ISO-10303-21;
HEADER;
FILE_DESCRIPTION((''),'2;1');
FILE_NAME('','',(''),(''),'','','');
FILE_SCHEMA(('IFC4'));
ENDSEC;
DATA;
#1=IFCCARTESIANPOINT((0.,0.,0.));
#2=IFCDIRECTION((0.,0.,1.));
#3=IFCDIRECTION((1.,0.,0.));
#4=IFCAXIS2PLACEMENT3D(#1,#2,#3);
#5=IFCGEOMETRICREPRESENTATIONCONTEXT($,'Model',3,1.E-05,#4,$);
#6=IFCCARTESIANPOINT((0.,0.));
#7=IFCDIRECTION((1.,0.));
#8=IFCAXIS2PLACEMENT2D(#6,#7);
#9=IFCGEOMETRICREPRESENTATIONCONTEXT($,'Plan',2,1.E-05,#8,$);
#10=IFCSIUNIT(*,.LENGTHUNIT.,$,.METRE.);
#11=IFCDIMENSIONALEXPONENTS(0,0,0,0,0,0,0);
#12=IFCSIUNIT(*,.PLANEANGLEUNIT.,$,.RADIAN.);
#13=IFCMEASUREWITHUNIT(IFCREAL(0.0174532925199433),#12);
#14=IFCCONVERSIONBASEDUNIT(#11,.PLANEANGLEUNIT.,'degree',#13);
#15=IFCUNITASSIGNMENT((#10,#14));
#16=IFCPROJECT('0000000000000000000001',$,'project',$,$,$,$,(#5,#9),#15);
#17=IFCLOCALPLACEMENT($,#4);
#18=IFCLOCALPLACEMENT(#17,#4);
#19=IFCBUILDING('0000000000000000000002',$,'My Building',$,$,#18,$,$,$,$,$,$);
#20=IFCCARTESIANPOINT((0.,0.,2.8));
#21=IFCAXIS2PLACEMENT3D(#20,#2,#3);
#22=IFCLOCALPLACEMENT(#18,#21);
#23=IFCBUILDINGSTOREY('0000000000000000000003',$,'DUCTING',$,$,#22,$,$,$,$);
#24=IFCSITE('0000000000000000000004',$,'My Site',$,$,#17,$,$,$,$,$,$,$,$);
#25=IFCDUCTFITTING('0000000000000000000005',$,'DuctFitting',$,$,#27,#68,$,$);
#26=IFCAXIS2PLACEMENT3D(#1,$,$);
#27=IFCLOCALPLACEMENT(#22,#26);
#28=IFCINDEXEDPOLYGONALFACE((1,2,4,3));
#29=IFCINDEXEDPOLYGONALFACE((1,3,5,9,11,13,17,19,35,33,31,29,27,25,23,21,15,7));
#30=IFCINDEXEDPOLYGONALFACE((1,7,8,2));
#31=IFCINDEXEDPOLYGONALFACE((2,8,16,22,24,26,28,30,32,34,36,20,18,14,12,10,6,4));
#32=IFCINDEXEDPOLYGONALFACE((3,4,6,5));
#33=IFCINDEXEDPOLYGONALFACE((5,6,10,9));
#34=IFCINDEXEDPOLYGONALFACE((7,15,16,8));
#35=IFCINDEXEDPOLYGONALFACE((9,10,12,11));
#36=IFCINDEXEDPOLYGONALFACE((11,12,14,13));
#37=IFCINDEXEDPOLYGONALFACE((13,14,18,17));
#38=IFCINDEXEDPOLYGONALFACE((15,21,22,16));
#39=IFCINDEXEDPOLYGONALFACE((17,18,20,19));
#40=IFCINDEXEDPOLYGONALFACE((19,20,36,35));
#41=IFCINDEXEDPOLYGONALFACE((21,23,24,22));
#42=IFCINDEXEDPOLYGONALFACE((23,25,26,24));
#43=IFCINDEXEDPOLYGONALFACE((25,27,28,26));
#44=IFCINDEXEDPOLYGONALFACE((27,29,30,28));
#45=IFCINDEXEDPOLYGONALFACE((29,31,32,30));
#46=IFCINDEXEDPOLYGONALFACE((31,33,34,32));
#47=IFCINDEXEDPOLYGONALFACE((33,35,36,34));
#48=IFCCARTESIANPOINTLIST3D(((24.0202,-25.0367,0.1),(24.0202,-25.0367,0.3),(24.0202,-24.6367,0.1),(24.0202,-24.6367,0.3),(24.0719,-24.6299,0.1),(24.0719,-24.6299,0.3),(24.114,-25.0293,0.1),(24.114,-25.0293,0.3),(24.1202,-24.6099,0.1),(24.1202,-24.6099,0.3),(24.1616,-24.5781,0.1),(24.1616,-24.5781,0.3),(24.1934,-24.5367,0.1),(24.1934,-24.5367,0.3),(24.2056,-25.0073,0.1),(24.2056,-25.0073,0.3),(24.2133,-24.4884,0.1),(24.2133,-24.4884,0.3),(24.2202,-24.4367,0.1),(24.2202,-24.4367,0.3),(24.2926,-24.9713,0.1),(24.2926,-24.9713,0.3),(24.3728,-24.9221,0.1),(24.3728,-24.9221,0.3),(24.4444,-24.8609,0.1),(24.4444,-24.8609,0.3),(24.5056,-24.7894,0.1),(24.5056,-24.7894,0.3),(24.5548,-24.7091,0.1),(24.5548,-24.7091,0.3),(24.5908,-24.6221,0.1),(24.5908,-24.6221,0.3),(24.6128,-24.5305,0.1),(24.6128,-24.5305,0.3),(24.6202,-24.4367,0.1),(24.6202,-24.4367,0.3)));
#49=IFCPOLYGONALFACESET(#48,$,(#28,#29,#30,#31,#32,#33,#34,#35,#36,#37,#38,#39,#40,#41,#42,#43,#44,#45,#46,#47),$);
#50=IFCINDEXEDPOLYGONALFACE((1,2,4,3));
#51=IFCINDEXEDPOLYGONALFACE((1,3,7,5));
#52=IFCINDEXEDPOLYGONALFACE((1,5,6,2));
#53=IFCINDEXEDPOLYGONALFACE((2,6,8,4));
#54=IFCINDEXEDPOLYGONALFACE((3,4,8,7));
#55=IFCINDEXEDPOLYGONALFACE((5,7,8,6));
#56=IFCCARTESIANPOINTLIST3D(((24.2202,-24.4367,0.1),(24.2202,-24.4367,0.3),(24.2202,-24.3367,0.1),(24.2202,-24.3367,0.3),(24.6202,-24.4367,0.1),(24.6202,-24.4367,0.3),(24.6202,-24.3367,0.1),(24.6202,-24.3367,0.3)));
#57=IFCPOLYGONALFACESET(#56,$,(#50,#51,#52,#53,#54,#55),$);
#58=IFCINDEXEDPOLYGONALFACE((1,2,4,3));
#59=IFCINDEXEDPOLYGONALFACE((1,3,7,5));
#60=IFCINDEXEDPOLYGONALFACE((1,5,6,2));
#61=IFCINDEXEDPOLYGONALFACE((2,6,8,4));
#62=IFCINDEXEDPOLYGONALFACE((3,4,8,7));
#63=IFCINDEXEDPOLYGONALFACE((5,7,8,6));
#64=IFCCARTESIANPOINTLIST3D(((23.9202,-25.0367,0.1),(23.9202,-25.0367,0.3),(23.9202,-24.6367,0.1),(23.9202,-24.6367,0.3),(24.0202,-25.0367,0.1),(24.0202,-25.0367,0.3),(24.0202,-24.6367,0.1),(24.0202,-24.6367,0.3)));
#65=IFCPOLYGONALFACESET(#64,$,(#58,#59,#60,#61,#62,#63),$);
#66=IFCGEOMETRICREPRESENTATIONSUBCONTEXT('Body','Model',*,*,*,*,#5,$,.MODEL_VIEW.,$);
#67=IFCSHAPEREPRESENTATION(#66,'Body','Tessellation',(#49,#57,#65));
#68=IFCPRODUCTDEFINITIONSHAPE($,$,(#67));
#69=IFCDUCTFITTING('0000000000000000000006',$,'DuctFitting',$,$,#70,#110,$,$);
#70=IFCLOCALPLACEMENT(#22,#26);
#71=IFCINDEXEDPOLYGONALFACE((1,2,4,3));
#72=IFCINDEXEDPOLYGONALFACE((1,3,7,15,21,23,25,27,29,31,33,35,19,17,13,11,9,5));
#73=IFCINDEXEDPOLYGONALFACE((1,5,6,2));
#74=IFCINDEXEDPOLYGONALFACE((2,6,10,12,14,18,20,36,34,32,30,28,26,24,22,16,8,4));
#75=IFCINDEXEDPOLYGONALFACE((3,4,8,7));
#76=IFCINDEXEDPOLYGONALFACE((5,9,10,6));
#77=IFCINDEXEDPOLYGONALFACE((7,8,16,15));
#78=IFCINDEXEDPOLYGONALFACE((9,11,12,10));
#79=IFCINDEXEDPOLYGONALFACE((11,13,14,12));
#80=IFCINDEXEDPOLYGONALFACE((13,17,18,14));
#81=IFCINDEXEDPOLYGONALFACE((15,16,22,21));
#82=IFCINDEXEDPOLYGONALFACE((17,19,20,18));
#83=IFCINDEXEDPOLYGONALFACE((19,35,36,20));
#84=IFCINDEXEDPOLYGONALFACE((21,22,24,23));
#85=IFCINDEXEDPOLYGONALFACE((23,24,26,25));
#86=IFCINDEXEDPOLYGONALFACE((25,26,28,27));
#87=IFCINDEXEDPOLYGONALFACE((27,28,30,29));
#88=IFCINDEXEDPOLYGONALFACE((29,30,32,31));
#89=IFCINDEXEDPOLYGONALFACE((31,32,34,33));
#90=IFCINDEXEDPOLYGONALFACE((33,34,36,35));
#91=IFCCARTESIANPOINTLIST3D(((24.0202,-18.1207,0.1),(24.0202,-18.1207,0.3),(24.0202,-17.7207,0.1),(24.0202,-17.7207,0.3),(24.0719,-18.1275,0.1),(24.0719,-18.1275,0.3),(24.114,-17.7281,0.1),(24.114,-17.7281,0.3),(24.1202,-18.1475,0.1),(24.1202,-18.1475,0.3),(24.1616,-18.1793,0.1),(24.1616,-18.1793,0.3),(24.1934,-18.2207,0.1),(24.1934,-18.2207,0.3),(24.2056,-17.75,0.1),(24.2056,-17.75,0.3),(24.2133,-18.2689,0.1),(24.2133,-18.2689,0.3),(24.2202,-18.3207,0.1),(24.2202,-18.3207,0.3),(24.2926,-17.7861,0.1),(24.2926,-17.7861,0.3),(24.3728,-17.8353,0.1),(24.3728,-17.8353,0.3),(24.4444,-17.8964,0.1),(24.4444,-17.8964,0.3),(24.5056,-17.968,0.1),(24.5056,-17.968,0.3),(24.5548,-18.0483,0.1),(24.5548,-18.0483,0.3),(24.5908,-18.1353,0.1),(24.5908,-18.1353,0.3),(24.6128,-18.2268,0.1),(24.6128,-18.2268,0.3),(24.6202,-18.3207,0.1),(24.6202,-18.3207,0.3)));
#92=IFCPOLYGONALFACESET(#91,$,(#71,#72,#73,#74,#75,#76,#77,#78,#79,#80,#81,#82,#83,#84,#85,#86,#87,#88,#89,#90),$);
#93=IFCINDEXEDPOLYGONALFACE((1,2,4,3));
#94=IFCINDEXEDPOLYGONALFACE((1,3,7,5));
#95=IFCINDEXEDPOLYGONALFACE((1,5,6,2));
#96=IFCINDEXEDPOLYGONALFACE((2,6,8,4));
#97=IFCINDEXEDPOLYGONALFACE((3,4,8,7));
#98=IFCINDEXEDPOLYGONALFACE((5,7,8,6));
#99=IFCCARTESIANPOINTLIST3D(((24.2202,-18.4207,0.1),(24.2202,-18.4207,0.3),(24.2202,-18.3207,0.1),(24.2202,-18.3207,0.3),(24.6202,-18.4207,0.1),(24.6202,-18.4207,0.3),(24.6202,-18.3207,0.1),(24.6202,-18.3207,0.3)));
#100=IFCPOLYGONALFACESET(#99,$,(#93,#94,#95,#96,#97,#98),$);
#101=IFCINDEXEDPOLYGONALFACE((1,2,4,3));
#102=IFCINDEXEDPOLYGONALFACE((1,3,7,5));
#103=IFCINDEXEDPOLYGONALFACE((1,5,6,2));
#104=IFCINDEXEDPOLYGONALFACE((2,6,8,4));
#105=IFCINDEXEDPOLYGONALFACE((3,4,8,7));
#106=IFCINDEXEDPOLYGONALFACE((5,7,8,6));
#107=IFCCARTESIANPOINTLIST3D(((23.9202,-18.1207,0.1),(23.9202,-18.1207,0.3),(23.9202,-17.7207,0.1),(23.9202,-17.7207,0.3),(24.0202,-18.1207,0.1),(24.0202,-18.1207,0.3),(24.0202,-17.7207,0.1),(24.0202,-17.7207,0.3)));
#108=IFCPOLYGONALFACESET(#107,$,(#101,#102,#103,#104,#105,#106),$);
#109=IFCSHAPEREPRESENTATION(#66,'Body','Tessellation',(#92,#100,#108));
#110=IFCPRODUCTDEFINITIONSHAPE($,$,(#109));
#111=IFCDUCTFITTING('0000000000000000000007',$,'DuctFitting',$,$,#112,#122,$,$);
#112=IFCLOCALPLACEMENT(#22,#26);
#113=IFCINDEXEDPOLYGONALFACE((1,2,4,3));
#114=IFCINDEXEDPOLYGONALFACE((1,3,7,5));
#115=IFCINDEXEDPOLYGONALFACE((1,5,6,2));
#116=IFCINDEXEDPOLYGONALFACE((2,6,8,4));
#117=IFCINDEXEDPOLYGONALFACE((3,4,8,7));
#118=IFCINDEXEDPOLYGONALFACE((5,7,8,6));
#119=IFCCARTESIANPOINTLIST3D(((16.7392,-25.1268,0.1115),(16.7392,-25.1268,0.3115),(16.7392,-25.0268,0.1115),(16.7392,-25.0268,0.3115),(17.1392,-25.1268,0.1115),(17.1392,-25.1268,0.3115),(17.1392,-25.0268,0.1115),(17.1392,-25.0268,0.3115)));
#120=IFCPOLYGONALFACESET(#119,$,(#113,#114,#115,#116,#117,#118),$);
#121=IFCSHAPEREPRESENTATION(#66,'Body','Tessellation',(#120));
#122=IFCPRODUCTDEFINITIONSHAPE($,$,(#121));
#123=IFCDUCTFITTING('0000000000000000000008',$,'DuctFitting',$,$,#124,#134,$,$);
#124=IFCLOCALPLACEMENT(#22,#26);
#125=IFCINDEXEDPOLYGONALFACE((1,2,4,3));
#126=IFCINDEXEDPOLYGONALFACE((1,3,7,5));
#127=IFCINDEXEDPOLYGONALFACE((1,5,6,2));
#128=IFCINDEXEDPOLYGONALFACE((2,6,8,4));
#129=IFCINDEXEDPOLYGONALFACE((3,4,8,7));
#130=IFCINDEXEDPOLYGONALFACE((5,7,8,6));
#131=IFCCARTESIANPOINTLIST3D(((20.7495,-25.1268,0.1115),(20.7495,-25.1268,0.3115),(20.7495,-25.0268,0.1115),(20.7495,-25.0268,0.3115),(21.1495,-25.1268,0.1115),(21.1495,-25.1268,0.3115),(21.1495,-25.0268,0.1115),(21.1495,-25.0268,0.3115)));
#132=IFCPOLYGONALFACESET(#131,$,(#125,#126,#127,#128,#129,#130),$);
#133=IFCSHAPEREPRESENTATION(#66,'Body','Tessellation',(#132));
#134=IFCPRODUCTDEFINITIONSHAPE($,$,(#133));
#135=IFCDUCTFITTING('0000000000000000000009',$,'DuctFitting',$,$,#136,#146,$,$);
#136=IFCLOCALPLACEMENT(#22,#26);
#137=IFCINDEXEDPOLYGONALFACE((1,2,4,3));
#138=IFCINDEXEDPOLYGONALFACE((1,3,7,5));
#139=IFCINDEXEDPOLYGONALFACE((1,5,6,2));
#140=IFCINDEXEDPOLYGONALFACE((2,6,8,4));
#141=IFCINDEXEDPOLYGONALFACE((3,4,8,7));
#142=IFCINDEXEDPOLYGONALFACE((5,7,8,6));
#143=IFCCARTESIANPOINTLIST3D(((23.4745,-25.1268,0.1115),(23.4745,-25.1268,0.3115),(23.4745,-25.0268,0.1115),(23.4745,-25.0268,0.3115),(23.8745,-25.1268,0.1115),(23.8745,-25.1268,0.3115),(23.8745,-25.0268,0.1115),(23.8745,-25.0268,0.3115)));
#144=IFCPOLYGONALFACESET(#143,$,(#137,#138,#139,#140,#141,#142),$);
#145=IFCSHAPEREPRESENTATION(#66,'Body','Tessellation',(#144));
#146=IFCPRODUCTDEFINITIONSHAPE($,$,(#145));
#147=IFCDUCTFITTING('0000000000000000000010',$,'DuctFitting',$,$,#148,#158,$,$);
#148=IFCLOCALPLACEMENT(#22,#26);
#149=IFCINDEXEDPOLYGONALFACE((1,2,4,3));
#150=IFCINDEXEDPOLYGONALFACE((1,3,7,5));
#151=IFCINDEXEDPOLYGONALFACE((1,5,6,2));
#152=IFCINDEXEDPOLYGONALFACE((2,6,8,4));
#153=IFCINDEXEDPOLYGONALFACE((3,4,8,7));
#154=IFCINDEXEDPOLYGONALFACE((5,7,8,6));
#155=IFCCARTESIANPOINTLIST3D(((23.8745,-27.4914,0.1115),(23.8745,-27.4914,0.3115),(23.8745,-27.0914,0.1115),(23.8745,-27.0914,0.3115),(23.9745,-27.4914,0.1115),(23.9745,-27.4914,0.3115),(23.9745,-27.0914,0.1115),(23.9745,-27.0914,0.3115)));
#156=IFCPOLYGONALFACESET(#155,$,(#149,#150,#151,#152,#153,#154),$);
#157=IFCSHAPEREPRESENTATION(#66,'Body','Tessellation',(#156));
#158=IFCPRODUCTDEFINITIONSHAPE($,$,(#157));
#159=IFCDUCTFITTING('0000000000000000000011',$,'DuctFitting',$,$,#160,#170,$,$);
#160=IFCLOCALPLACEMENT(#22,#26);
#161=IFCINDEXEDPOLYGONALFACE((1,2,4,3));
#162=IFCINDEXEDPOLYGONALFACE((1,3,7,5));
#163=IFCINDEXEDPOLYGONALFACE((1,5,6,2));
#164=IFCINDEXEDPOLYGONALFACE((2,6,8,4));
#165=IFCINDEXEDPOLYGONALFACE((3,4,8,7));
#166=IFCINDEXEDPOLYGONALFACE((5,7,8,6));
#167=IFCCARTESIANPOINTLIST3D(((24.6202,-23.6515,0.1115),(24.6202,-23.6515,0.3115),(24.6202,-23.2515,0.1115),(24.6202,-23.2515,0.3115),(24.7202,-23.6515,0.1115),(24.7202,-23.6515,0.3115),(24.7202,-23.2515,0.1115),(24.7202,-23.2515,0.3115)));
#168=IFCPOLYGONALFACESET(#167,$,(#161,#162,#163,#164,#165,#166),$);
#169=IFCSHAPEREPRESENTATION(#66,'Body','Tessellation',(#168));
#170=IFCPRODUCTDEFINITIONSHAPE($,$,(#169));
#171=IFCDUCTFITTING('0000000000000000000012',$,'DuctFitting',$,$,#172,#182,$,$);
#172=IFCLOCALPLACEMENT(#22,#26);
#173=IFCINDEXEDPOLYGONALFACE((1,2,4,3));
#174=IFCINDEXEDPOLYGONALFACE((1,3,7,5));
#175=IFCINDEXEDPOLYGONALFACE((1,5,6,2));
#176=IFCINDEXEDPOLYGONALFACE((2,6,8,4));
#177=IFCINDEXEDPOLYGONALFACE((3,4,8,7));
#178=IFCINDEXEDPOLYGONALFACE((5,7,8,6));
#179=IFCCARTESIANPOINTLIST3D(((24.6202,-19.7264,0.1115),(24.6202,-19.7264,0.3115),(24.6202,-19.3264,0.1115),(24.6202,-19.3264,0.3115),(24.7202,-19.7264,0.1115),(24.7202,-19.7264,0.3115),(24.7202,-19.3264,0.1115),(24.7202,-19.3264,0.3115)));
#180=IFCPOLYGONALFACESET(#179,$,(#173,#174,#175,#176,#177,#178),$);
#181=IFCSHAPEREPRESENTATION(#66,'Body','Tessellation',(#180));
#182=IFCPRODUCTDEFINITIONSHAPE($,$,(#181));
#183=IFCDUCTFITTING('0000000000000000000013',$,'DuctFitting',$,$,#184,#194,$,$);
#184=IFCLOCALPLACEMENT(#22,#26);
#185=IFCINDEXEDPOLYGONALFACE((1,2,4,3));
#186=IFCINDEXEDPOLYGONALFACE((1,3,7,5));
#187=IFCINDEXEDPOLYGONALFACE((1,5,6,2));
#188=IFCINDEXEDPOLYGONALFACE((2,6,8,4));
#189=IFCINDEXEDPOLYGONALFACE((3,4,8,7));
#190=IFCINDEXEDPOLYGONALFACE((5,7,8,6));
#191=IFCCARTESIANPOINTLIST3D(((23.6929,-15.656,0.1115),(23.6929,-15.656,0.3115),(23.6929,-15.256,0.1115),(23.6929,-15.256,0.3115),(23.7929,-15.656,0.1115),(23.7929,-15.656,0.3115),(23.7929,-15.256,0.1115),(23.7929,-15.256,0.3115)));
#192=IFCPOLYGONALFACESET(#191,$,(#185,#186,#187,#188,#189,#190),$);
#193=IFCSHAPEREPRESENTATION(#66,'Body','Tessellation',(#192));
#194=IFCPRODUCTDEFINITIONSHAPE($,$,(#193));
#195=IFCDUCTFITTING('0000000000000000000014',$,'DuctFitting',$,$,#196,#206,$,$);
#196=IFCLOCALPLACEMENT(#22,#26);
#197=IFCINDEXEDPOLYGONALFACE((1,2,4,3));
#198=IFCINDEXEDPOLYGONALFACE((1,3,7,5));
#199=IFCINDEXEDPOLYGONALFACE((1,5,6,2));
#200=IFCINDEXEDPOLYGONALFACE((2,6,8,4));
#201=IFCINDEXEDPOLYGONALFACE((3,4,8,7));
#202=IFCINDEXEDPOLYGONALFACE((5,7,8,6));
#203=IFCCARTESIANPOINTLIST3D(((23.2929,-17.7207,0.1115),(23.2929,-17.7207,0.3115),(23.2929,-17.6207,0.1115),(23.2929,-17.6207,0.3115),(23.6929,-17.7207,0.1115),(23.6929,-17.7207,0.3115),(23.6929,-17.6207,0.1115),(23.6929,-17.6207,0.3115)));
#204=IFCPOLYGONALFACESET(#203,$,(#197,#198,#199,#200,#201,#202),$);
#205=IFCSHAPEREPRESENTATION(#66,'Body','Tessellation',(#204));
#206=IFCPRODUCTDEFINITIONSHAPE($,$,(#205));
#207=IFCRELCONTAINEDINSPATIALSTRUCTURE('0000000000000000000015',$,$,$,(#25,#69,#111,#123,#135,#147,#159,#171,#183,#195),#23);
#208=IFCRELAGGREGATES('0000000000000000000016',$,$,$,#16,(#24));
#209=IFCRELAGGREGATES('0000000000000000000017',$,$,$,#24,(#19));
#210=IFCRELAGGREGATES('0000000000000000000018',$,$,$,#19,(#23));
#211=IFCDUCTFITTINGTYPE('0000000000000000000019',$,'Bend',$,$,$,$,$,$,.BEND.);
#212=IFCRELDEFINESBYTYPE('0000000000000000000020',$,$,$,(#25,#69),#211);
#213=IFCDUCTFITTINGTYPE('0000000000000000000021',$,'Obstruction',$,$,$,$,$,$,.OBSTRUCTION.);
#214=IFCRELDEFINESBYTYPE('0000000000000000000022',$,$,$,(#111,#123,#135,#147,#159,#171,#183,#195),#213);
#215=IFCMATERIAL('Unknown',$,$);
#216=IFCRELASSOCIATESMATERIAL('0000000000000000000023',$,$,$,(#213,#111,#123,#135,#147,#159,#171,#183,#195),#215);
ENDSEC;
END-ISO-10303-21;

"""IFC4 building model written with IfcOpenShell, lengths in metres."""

from ifc_helpers import new_model, entity, si_unit, converted_unit, frame, origin_with_axes, origin_2d_with_axis, place, context, subcontext, project, spatial, line, arc, indexed_curve, rectangle, outline, extrude, source, transform, mapped, material, material_profile, profile_set, profile_usage, type_object, type_shapes, element, save


model = new_model("IFC4")

# Units and contexts
model_context = context("Model", 3, precision=1e-05, world=origin_with_axes())
plan_context = context("Plan", 2, precision=1e-05, world=origin_2d_with_axis())
body_context = subcontext(model_context, "Body", "Model", "MODEL_VIEW")
ifc_project = project(units=[si_unit("LENGTHUNIT", "METRE"), converted_unit("PLANEANGLEUNIT", "degree", entity("IfcReal", 0.0174532925199433), si_unit("PLANEANGLEUNIT", "RADIAN"), dimensions=[0, 0, 0, 0, 0, 0, 0])], contexts=[model_context, plan_context])

# Site, building, storey
site_placement = place(None, origin_with_axes())
site = spatial("IfcSite", under=ifc_project, at=site_placement, Name="My Site")
building_placement = place(site_placement, origin_with_axes())
building = spatial("IfcBuilding", under=site, at=building_placement, Name="My Building")
storey_placement = place(building_placement, frame((0.0, 0.0, 2.8), z_axis=(0.0, 0.0, 1.0), x_axis=(1.0, 0.0, 0.0)))
storey = spatial("IfcBuildingStorey", under=building, at=storey_placement, Name="DUCTING")

# Shared definitions
ifc_material = material(Name="Unknown")

# Duct fittings
duct_fitting_type_1 = type_object("IfcDuctFittingType", Name="Bend", PredefinedType="BEND")
shared_shape = source(origin_with_axes(), body_context, "Body", "SweptSolid", [
    extrude(outline(indexed_curve([(-0.2, 0.0), (-0.2586, -0.1414), (-0.4, -0.2), (-0.4, -0.6), (0.0243, -0.4243), (0.2, 0.0)], segments=[arc(1, 2, 3), line(3, 4), arc(4, 5, 6), line(6, 1)])), frame((0.0, -0.1, -0.1), z_axis=(0.0, -1.0, 0.0), x_axis=(1.0, 0.0, 0.0)), (0.0, 0.0, -1.0), 0.2),
    extrude(rectangle(XDim=0.4, YDim=0.2), origin_with_axes(), (0.0, 0.0, -1.0), 0.1),
    extrude(rectangle(XDim=0.4, YDim=0.2), frame((-0.4, 0.0, -0.5), z_axis=(-1.0, 0.0, 0.0), x_axis=(0.0, 0.0, -1.0)), (0.0, 0.0, 1.0), 0.1),
])
type_shapes(duct_fitting_type_1, [shared_shape])
for number, where, z_axis, x_axis, name in (
    (1, (24.4202, -24.3367, 0.2), (0.0, 1.0, 0.0), (1.0, 0.0, 0.0), "DuctFitting"),
    (2, (24.4202, -18.4207, 0.2), (0.0, -1.0, 0.0), (1.0, 0.0, 0.0), "DuctFitting"),
):
    element("IfcDuctFitting", number, at=place(storey_placement, frame(where, z_axis=z_axis, x_axis=x_axis)), inside=storey, type_object=duct_fitting_type_1, Name=name, context=body_context, shape_type="MappedRepresentation", body=[
        mapped(shared_shape, transform((0.0, 0.0, 0.0), x_axis=(1.0, 0.0, 0.0), y_axis=(0.0, 1.0, 0.0), z_axis=(0.0, 0.0, 1.0), scale=1.0)),
    ])
ifc_material_profile_1 = material_profile(ifc_material, rectangle(XDim=0.4, YDim=0.2))
ifc_profile_set_1 = profile_set([ifc_material_profile_1])
ifc_profile_usage_1 = profile_usage(ifc_profile_set_1, cardinal=5)
duct_fitting_type_2 = type_object("IfcDuctFittingType", Name="Obstruction", PredefinedType="OBSTRUCTION", material=ifc_profile_set_1)
duct_fitting_1_placement = place(storey_placement, frame((16.9392, -25.0268, 0.2115), z_axis=(-0.000018, -1.0, 0.000001), x_axis=(1.0, -0.000018, 0.0)))
element("IfcDuctFitting", 3, at=duct_fitting_1_placement, inside=storey, type_object=duct_fitting_type_2, material=ifc_profile_usage_1, Name="DuctFitting", context=body_context, shape_type="SweptSolid", body=[
    extrude(rectangle(XDim=0.4, YDim=0.2), origin_with_axes(), (0.0, 0.0, 1.0), 0.1),
])
ifc_profile_usage_2 = profile_usage(ifc_profile_set_1, cardinal=5)
duct_fitting_2_placement = place(storey_placement, frame((20.9495, -25.0268, 0.2115), z_axis=(-0.000018, -1.0, 0.000001), x_axis=(1.0, -0.000018, 0.0)))
element("IfcDuctFitting", 4, at=duct_fitting_2_placement, inside=storey, type_object=duct_fitting_type_2, material=ifc_profile_usage_2, Name="DuctFitting", context=body_context, shape_type="SweptSolid", body=[
    extrude(rectangle(XDim=0.4, YDim=0.2), origin_with_axes(), (0.0, 0.0, 1.0), 0.1),
])
ifc_profile_usage_3 = profile_usage(ifc_profile_set_1, cardinal=5)
duct_fitting_3_placement = place(storey_placement, frame((23.6745, -25.0268, 0.2115), z_axis=(-0.000018, -1.0, 0.000001), x_axis=(1.0, -0.000018, 0.0)))
element("IfcDuctFitting", 5, at=duct_fitting_3_placement, inside=storey, type_object=duct_fitting_type_2, material=ifc_profile_usage_3, Name="DuctFitting", context=body_context, shape_type="SweptSolid", body=[
    extrude(rectangle(XDim=0.4, YDim=0.2), origin_with_axes(), (0.0, 0.0, 1.0), 0.1),
])
ifc_profile_usage_4 = profile_usage(ifc_profile_set_1, cardinal=5)
duct_fitting_4_placement = place(storey_placement, frame((23.8745, -27.2914, 0.2115), z_axis=(1.0, -0.000018, 0.000001), x_axis=(0.000018, 1.0, 0.0)))
element("IfcDuctFitting", 6, at=duct_fitting_4_placement, inside=storey, type_object=duct_fitting_type_2, material=ifc_profile_usage_4, Name="DuctFitting", context=body_context, shape_type="SweptSolid", body=[
    extrude(rectangle(XDim=0.4, YDim=0.2), origin_with_axes(), (0.0, 0.0, 1.0), 0.1),
])
ifc_profile_usage_5 = profile_usage(ifc_profile_set_1, cardinal=5)
duct_fitting_5_placement = place(storey_placement, frame((24.6202, -23.4515, 0.2115), z_axis=(1.0, 0.0, 0.0), x_axis=(0.0, 1.0, 0.0)))
element("IfcDuctFitting", 7, at=duct_fitting_5_placement, inside=storey, type_object=duct_fitting_type_2, material=ifc_profile_usage_5, Name="DuctFitting", context=body_context, shape_type="SweptSolid", body=[
    extrude(rectangle(XDim=0.4, YDim=0.2), origin_with_axes(), (0.0, 0.0, 1.0), 0.1),
])
ifc_profile_usage_6 = profile_usage(ifc_profile_set_1, cardinal=5)
duct_fitting_6_placement = place(storey_placement, frame((24.6202, -19.5264, 0.2115), z_axis=(1.0, 0.0, 0.0), x_axis=(0.0, 1.0, 0.0)))
element("IfcDuctFitting", 8, at=duct_fitting_6_placement, inside=storey, type_object=duct_fitting_type_2, material=ifc_profile_usage_6, Name="DuctFitting", context=body_context, shape_type="SweptSolid", body=[
    extrude(rectangle(XDim=0.4, YDim=0.2), origin_with_axes(), (0.0, 0.0, 1.0), 0.1),
])
ifc_profile_usage_7 = profile_usage(ifc_profile_set_1, cardinal=5)
duct_fitting_7_placement = place(storey_placement, frame((23.6929, -15.456, 0.2115), z_axis=(1.0, -0.000018, 0.000001), x_axis=(0.000018, 1.0, 0.0)))
element("IfcDuctFitting", 9, at=duct_fitting_7_placement, inside=storey, type_object=duct_fitting_type_2, material=ifc_profile_usage_7, Name="DuctFitting", context=body_context, shape_type="SweptSolid", body=[
    extrude(rectangle(XDim=0.4, YDim=0.2), origin_with_axes(), (0.0, 0.0, 1.0), 0.1),
])
ifc_profile_usage_8 = profile_usage(ifc_profile_set_1, cardinal=5)
duct_fitting_8_placement = place(storey_placement, frame((23.4929, -17.7207, 0.2115), z_axis=(0.000018, 1.0, 0.000001), x_axis=(-1.0, 0.000018, 0.0)))
element("IfcDuctFitting", 10, at=duct_fitting_8_placement, inside=storey, type_object=duct_fitting_type_2, material=ifc_profile_usage_8, Name="DuctFitting", context=body_context, shape_type="SweptSolid", body=[
    extrude(rectangle(XDim=0.4, YDim=0.2), origin_with_axes(), (0.0, 0.0, 1.0), 0.1),
])

save(model, "model.ifc")
